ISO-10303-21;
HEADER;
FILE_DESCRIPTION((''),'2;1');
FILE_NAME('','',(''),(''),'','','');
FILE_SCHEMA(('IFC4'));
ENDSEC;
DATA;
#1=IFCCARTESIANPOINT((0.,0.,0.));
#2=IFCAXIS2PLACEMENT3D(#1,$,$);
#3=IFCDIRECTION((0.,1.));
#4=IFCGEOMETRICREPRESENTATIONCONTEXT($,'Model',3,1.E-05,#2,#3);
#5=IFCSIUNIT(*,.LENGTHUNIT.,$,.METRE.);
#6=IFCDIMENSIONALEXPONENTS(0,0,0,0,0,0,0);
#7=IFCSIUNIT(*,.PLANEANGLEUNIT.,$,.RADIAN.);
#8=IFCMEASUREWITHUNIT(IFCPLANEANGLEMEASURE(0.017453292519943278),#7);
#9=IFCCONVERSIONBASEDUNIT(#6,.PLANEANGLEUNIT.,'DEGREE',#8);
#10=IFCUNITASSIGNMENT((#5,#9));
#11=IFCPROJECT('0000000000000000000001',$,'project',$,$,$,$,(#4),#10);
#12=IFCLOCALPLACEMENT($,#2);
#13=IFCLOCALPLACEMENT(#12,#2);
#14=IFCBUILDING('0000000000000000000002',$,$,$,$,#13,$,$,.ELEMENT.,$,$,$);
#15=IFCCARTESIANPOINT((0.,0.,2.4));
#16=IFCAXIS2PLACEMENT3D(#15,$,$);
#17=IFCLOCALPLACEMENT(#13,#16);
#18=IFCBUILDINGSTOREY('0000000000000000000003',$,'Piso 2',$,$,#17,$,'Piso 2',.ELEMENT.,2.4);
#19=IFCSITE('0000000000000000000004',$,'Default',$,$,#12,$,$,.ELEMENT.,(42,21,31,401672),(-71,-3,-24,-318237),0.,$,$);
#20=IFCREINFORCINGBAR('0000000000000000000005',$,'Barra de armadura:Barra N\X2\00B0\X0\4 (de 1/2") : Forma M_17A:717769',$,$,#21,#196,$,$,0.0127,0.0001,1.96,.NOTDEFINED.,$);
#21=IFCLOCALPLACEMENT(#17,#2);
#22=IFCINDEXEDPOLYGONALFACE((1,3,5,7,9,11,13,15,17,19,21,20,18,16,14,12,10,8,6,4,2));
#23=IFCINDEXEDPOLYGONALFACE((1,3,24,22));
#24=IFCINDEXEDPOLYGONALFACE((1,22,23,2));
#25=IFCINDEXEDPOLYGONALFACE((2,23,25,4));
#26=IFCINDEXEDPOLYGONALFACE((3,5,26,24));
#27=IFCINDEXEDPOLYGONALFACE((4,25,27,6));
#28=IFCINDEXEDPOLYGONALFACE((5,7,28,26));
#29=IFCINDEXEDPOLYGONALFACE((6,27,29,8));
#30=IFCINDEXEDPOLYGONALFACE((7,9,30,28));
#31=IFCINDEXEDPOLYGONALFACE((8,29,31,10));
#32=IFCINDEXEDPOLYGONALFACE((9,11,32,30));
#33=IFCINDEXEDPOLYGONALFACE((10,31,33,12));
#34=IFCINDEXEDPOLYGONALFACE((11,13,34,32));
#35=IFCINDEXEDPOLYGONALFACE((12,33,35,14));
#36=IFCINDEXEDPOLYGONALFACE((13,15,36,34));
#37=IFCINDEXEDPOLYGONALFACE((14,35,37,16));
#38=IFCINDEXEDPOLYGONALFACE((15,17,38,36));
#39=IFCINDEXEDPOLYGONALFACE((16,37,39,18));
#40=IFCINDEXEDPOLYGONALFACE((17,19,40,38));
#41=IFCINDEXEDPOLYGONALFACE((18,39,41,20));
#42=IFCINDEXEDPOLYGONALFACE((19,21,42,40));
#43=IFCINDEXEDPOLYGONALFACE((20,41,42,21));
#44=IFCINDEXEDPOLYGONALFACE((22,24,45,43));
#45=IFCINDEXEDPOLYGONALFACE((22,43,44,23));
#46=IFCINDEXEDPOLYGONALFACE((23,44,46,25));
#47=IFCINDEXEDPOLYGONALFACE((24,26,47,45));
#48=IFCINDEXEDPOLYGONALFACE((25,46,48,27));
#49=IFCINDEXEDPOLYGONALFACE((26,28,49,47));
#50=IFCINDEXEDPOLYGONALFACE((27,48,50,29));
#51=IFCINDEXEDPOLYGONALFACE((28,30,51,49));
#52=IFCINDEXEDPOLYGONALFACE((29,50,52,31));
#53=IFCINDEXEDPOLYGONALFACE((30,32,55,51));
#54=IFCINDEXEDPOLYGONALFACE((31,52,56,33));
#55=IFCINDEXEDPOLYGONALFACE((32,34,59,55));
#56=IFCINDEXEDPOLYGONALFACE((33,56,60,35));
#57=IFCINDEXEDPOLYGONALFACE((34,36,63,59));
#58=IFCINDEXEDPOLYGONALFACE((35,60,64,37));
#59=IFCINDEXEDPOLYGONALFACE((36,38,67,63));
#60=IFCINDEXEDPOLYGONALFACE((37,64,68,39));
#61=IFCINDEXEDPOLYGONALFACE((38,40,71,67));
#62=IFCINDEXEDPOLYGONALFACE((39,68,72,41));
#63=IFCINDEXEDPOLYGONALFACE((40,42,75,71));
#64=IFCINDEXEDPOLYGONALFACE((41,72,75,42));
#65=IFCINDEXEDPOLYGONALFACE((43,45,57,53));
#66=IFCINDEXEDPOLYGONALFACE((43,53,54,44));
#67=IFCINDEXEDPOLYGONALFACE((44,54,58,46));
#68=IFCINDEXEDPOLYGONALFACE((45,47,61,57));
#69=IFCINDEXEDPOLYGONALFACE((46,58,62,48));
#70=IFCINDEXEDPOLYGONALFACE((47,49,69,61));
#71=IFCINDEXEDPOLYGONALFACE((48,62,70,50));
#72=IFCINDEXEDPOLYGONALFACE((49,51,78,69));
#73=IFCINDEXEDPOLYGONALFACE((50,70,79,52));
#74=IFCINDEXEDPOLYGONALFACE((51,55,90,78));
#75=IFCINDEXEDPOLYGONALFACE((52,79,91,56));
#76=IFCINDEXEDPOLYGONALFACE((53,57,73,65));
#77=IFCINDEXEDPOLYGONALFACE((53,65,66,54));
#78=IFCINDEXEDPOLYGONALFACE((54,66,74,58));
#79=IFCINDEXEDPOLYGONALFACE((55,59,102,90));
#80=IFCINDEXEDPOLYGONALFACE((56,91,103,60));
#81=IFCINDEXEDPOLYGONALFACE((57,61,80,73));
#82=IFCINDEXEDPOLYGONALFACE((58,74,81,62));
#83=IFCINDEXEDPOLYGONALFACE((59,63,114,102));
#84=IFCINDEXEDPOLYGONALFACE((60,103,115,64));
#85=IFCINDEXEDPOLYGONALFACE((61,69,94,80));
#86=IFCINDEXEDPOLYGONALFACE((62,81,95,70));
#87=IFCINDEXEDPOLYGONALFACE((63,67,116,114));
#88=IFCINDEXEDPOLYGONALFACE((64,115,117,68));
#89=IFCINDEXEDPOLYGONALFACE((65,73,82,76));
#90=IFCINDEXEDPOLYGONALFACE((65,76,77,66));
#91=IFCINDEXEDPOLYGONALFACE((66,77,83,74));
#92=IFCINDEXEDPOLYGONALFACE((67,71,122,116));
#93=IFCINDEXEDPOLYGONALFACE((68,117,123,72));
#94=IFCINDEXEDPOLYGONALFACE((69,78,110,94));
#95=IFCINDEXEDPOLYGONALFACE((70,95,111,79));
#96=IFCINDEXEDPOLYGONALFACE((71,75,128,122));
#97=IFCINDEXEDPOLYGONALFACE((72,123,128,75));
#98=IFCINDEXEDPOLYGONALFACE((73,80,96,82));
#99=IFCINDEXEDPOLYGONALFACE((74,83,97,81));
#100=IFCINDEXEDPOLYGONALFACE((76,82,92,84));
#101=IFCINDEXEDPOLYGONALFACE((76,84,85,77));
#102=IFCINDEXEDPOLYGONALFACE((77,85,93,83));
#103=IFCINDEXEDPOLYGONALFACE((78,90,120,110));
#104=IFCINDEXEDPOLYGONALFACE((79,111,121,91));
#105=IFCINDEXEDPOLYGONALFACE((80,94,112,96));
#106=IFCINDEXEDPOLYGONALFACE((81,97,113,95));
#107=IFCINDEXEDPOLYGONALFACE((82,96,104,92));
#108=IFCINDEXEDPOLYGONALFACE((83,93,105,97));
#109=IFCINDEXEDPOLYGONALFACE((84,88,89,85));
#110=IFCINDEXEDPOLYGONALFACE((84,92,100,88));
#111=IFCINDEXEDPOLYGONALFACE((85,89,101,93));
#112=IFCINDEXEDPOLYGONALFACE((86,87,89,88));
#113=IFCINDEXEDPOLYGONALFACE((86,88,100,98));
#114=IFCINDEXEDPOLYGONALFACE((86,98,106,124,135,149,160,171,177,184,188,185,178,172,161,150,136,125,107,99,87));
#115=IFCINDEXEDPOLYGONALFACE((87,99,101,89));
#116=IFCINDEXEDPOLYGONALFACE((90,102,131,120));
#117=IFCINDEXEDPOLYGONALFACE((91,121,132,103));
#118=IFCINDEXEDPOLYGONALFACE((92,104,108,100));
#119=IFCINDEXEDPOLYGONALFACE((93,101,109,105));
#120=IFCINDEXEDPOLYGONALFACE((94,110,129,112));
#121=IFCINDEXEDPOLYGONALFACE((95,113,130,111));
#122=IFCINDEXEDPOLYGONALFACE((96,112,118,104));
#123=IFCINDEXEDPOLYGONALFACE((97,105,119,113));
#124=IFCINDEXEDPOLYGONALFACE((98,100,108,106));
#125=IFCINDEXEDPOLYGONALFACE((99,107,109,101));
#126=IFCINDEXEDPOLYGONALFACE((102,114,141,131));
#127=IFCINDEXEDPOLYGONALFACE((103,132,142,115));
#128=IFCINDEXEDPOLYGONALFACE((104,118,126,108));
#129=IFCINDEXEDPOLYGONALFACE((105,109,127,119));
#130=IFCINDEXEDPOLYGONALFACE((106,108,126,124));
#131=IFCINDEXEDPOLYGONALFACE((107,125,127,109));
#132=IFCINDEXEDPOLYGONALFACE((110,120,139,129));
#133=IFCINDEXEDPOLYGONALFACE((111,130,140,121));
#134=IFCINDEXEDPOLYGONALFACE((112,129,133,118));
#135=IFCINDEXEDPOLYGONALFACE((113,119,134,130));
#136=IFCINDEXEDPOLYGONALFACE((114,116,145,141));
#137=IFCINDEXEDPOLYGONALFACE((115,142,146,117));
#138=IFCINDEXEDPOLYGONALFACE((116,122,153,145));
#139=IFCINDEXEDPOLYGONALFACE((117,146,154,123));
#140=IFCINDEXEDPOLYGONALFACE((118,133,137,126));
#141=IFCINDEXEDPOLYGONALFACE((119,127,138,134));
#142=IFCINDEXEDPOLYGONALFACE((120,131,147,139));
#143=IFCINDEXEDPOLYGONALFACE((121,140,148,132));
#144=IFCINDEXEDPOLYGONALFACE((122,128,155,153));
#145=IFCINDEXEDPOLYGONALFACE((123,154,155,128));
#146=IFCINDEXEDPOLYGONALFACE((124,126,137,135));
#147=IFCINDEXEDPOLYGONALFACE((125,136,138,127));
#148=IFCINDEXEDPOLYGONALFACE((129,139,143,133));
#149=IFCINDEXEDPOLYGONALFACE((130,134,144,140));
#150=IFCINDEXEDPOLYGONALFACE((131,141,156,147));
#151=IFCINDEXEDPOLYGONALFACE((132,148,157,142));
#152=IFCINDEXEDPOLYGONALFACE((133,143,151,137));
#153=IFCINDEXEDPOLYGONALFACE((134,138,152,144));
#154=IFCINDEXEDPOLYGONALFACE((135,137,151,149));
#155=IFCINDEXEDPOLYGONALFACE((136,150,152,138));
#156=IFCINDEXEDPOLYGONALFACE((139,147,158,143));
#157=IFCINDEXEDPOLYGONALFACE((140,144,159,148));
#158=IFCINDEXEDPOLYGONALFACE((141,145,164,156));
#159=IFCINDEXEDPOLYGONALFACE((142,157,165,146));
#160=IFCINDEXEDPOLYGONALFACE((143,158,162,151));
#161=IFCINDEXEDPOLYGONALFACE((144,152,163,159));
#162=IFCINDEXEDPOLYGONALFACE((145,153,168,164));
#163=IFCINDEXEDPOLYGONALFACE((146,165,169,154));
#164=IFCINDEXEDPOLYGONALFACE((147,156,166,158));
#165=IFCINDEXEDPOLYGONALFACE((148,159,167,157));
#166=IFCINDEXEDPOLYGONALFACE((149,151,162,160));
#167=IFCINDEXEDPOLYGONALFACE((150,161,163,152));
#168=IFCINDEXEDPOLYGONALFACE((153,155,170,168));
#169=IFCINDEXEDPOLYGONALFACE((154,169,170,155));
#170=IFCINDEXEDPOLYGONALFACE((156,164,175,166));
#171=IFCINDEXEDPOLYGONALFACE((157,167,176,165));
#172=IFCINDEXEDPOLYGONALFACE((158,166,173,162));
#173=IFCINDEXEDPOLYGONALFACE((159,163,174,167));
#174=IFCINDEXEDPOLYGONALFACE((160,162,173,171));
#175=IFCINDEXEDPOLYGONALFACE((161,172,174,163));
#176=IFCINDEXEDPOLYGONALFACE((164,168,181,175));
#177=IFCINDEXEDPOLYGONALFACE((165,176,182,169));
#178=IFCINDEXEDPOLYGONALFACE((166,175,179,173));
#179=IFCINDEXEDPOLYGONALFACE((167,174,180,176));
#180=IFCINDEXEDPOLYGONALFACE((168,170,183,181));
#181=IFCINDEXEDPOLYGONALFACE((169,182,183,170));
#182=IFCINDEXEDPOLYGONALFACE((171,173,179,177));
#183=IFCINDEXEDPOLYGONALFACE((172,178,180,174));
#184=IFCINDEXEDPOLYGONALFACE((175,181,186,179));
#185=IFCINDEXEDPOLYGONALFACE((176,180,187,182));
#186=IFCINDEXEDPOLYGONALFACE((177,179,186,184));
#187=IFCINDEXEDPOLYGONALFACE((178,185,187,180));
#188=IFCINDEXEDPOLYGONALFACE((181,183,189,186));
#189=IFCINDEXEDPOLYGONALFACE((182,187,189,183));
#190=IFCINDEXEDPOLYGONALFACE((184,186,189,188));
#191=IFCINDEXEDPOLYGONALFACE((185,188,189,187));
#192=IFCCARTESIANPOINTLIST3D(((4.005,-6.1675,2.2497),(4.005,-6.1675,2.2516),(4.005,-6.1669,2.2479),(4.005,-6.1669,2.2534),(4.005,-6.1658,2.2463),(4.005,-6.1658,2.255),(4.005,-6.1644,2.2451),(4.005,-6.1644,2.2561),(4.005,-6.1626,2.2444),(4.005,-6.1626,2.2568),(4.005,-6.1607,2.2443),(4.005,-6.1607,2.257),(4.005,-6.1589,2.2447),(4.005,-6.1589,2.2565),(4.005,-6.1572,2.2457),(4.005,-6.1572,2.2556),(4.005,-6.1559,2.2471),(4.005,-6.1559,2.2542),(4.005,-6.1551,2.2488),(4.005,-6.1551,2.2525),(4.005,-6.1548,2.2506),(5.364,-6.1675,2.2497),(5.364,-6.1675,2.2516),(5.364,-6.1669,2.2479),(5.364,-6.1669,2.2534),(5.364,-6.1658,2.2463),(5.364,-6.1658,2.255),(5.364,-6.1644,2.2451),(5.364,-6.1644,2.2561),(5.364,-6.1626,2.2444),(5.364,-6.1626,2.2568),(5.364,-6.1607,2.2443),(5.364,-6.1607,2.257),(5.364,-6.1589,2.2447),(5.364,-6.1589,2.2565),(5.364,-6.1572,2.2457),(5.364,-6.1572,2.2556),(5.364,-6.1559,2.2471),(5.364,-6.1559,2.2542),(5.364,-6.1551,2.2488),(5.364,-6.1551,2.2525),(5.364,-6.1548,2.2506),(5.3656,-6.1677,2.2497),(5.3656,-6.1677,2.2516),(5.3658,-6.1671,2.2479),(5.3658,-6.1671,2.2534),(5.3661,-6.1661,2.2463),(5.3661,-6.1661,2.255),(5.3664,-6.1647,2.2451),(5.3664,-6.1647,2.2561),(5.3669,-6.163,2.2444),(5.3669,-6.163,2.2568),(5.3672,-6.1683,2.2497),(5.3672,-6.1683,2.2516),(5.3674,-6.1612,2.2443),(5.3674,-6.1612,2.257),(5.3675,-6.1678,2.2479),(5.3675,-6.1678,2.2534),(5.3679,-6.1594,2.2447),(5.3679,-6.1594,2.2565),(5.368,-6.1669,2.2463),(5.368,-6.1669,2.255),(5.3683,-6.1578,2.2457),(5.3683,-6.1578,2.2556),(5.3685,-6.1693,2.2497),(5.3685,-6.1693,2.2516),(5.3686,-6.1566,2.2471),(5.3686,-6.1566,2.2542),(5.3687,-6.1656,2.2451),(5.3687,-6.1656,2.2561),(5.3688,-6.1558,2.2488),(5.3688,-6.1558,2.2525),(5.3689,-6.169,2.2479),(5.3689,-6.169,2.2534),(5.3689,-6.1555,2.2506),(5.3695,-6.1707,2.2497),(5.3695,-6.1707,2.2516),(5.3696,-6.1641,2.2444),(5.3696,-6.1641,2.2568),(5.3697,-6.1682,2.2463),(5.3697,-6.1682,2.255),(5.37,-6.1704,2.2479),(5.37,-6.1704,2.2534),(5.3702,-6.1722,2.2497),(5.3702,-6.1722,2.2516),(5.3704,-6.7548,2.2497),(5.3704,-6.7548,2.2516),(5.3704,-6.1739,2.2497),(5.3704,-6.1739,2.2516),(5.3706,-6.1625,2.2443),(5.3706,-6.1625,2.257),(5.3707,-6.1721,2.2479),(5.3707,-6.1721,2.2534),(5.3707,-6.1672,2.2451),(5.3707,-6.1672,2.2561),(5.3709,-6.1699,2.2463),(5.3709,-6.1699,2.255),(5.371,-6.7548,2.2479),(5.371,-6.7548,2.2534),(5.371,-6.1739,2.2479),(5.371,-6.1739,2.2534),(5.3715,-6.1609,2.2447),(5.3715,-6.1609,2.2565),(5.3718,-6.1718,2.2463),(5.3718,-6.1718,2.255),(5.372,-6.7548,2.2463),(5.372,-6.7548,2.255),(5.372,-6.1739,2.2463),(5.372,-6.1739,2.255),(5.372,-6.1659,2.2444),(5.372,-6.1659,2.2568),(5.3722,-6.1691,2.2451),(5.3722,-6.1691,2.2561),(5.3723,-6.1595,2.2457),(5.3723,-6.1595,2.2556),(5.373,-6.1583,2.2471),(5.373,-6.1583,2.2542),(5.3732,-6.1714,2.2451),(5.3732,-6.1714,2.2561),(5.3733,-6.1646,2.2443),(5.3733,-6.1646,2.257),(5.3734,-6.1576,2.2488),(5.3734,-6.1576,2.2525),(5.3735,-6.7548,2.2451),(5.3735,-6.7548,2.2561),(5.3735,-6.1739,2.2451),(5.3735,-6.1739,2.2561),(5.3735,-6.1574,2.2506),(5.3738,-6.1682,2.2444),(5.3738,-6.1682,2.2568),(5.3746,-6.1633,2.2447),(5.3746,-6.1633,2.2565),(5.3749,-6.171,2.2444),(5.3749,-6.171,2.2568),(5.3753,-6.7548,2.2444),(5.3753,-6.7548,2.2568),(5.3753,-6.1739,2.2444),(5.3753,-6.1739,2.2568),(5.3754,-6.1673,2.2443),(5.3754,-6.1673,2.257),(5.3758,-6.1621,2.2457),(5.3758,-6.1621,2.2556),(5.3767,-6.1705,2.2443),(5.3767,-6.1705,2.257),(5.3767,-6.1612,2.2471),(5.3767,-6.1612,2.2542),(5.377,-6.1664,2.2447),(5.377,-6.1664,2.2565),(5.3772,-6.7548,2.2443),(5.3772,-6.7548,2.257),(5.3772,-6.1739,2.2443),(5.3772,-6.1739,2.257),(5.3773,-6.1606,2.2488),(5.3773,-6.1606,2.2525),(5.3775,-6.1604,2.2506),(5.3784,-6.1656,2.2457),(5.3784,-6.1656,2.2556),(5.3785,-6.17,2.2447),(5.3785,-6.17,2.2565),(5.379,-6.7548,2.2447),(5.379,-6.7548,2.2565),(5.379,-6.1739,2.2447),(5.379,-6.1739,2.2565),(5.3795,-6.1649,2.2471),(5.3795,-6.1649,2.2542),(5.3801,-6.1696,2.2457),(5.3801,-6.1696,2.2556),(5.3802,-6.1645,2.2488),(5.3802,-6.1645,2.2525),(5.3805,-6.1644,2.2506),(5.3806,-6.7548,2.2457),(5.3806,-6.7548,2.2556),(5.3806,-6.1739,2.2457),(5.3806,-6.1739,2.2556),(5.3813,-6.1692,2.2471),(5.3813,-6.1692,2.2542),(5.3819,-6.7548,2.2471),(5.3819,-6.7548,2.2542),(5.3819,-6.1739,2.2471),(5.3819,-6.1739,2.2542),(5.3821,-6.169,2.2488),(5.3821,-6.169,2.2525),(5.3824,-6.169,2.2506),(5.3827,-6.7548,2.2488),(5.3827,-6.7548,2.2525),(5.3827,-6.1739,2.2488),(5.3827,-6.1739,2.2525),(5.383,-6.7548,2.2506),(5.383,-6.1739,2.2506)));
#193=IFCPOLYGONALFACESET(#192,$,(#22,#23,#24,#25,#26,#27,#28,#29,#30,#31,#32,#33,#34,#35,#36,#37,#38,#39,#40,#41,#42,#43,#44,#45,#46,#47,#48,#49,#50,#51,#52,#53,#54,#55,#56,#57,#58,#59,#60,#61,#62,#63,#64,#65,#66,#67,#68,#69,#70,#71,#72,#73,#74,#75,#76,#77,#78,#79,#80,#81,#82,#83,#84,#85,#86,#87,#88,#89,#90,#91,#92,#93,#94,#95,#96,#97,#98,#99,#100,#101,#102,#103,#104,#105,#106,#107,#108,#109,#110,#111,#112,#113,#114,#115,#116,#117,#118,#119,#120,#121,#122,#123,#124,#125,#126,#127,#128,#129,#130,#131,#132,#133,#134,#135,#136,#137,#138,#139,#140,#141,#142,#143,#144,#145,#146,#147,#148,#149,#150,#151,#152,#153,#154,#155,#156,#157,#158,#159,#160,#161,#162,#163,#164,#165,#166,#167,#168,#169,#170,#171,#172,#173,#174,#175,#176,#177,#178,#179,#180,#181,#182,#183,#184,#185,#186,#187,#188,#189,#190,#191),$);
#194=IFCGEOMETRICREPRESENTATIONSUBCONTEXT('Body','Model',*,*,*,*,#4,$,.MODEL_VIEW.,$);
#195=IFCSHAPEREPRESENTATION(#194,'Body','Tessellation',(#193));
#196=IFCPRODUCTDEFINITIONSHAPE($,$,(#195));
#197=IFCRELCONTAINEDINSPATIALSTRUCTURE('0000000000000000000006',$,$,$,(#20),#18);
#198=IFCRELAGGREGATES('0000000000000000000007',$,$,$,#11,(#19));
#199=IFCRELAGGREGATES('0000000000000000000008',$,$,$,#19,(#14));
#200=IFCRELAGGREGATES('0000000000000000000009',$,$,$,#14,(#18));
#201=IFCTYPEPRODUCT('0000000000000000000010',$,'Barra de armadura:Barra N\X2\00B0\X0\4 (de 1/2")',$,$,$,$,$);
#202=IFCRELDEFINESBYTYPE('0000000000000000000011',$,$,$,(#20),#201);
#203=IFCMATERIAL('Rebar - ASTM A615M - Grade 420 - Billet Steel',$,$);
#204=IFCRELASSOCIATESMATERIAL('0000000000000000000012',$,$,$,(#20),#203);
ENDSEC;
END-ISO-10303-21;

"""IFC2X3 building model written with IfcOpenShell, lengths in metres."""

from ifc_helpers import new_model, entity, si_unit, converted_unit, direction, frame, origin, place, context, subcontext, project, spatial, material, type_object, element, save


model = new_model("IFC2X3")

# Units and contexts
model_context = context("Model", 3, precision=1e-05, world=origin(), true_north=direction((0.0, 1.0)))
body_context = subcontext(model_context, "Body", "Model", "MODEL_VIEW")
ifc_project = project(units=[si_unit("LENGTHUNIT", "METRE"), converted_unit("PLANEANGLEUNIT", "DEGREE", entity("IfcPlaneAngleMeasure", 0.017453292519943278), si_unit("PLANEANGLEUNIT", "RADIAN"), dimensions=[0, 0, 0, 0, 0, 0, 0])], contexts=[model_context])

# Site, building, storey
site_placement = place(None, origin())
site = spatial("IfcSite", under=ifc_project, at=site_placement, Name="Default", CompositionType="ELEMENT", RefLatitude=(42, 21, 31, 401672), RefLongitude=(-71, -3, -24, -318237), RefElevation=0.0)
building_placement = place(site_placement, origin())
building = spatial("IfcBuilding", under=site, at=building_placement, CompositionType="ELEMENT")
storey_placement = place(building_placement, frame((0.0, 0.0, 2.4)))
storey = spatial("IfcBuildingStorey", under=building, at=storey_placement, Name="Piso 2", LongName="Piso 2", CompositionType="ELEMENT", Elevation=2.4)

# Reinforcing bar
ifc_material_1 = material(Name="Rebar - ASTM A615M - Grade 420 - Billet Steel")
type_product_1 = type_object("IfcTypeProduct", Name="Barra de armadura:Barra N°4 (de 1/2\")")
reinforcing_bar_1_placement = place(storey_placement, origin())
element("IfcReinforcingBar", 1, at=reinforcing_bar_1_placement, inside=storey, type_object=type_product_1, material=ifc_material_1, Name="Barra de armadura:Barra N°4 (de 1/2\") : Forma M_17A:717769", BarLength=1.96, BarRole="NOTDEFINED", CrossSectionArea=0.0001, NominalDiameter=0.0127, context=body_context, shape_type="AdvancedSweptSolid", body=[
    entity("IfcSweptDiskSolid", entity("IfcCompositeCurve", [entity("IfcCompositeCurveSegment", "CONTINUOUS", True, entity("IfcPolyline", [entity("IfcCartesianPoint", [4.005, -6.1612, 2.2506]), entity("IfcCartesianPoint", [5.364, -6.1612, 2.2506])])), entity("IfcCompositeCurveSegment", "CONTINUOUS", True, entity("IfcTrimmedCurve", entity("IfcCircle", entity("IfcAxis2Placement3D", entity("IfcCartesianPoint", [5.364, -6.1739, 2.2506]), entity("IfcDirection", [0.0, 0.0, -1.0]), entity("IfcDirection", [1.0, 0.0, 0.0])), 0.0127), [entity("IfcParameterValue", 270.0)], [entity("IfcParameterValue", 360.0)], True, "PARAMETER")), entity("IfcCompositeCurveSegment", "CONTINUOUS", True, entity("IfcPolyline", [entity("IfcCartesianPoint", [5.3767, -6.1739, 2.2506]), entity("IfcCartesianPoint", [5.3767, -6.7548, 2.2506])]))], False), 0.0063, None, 0.0, 92.0),
])

save(model, "model.ifc")
